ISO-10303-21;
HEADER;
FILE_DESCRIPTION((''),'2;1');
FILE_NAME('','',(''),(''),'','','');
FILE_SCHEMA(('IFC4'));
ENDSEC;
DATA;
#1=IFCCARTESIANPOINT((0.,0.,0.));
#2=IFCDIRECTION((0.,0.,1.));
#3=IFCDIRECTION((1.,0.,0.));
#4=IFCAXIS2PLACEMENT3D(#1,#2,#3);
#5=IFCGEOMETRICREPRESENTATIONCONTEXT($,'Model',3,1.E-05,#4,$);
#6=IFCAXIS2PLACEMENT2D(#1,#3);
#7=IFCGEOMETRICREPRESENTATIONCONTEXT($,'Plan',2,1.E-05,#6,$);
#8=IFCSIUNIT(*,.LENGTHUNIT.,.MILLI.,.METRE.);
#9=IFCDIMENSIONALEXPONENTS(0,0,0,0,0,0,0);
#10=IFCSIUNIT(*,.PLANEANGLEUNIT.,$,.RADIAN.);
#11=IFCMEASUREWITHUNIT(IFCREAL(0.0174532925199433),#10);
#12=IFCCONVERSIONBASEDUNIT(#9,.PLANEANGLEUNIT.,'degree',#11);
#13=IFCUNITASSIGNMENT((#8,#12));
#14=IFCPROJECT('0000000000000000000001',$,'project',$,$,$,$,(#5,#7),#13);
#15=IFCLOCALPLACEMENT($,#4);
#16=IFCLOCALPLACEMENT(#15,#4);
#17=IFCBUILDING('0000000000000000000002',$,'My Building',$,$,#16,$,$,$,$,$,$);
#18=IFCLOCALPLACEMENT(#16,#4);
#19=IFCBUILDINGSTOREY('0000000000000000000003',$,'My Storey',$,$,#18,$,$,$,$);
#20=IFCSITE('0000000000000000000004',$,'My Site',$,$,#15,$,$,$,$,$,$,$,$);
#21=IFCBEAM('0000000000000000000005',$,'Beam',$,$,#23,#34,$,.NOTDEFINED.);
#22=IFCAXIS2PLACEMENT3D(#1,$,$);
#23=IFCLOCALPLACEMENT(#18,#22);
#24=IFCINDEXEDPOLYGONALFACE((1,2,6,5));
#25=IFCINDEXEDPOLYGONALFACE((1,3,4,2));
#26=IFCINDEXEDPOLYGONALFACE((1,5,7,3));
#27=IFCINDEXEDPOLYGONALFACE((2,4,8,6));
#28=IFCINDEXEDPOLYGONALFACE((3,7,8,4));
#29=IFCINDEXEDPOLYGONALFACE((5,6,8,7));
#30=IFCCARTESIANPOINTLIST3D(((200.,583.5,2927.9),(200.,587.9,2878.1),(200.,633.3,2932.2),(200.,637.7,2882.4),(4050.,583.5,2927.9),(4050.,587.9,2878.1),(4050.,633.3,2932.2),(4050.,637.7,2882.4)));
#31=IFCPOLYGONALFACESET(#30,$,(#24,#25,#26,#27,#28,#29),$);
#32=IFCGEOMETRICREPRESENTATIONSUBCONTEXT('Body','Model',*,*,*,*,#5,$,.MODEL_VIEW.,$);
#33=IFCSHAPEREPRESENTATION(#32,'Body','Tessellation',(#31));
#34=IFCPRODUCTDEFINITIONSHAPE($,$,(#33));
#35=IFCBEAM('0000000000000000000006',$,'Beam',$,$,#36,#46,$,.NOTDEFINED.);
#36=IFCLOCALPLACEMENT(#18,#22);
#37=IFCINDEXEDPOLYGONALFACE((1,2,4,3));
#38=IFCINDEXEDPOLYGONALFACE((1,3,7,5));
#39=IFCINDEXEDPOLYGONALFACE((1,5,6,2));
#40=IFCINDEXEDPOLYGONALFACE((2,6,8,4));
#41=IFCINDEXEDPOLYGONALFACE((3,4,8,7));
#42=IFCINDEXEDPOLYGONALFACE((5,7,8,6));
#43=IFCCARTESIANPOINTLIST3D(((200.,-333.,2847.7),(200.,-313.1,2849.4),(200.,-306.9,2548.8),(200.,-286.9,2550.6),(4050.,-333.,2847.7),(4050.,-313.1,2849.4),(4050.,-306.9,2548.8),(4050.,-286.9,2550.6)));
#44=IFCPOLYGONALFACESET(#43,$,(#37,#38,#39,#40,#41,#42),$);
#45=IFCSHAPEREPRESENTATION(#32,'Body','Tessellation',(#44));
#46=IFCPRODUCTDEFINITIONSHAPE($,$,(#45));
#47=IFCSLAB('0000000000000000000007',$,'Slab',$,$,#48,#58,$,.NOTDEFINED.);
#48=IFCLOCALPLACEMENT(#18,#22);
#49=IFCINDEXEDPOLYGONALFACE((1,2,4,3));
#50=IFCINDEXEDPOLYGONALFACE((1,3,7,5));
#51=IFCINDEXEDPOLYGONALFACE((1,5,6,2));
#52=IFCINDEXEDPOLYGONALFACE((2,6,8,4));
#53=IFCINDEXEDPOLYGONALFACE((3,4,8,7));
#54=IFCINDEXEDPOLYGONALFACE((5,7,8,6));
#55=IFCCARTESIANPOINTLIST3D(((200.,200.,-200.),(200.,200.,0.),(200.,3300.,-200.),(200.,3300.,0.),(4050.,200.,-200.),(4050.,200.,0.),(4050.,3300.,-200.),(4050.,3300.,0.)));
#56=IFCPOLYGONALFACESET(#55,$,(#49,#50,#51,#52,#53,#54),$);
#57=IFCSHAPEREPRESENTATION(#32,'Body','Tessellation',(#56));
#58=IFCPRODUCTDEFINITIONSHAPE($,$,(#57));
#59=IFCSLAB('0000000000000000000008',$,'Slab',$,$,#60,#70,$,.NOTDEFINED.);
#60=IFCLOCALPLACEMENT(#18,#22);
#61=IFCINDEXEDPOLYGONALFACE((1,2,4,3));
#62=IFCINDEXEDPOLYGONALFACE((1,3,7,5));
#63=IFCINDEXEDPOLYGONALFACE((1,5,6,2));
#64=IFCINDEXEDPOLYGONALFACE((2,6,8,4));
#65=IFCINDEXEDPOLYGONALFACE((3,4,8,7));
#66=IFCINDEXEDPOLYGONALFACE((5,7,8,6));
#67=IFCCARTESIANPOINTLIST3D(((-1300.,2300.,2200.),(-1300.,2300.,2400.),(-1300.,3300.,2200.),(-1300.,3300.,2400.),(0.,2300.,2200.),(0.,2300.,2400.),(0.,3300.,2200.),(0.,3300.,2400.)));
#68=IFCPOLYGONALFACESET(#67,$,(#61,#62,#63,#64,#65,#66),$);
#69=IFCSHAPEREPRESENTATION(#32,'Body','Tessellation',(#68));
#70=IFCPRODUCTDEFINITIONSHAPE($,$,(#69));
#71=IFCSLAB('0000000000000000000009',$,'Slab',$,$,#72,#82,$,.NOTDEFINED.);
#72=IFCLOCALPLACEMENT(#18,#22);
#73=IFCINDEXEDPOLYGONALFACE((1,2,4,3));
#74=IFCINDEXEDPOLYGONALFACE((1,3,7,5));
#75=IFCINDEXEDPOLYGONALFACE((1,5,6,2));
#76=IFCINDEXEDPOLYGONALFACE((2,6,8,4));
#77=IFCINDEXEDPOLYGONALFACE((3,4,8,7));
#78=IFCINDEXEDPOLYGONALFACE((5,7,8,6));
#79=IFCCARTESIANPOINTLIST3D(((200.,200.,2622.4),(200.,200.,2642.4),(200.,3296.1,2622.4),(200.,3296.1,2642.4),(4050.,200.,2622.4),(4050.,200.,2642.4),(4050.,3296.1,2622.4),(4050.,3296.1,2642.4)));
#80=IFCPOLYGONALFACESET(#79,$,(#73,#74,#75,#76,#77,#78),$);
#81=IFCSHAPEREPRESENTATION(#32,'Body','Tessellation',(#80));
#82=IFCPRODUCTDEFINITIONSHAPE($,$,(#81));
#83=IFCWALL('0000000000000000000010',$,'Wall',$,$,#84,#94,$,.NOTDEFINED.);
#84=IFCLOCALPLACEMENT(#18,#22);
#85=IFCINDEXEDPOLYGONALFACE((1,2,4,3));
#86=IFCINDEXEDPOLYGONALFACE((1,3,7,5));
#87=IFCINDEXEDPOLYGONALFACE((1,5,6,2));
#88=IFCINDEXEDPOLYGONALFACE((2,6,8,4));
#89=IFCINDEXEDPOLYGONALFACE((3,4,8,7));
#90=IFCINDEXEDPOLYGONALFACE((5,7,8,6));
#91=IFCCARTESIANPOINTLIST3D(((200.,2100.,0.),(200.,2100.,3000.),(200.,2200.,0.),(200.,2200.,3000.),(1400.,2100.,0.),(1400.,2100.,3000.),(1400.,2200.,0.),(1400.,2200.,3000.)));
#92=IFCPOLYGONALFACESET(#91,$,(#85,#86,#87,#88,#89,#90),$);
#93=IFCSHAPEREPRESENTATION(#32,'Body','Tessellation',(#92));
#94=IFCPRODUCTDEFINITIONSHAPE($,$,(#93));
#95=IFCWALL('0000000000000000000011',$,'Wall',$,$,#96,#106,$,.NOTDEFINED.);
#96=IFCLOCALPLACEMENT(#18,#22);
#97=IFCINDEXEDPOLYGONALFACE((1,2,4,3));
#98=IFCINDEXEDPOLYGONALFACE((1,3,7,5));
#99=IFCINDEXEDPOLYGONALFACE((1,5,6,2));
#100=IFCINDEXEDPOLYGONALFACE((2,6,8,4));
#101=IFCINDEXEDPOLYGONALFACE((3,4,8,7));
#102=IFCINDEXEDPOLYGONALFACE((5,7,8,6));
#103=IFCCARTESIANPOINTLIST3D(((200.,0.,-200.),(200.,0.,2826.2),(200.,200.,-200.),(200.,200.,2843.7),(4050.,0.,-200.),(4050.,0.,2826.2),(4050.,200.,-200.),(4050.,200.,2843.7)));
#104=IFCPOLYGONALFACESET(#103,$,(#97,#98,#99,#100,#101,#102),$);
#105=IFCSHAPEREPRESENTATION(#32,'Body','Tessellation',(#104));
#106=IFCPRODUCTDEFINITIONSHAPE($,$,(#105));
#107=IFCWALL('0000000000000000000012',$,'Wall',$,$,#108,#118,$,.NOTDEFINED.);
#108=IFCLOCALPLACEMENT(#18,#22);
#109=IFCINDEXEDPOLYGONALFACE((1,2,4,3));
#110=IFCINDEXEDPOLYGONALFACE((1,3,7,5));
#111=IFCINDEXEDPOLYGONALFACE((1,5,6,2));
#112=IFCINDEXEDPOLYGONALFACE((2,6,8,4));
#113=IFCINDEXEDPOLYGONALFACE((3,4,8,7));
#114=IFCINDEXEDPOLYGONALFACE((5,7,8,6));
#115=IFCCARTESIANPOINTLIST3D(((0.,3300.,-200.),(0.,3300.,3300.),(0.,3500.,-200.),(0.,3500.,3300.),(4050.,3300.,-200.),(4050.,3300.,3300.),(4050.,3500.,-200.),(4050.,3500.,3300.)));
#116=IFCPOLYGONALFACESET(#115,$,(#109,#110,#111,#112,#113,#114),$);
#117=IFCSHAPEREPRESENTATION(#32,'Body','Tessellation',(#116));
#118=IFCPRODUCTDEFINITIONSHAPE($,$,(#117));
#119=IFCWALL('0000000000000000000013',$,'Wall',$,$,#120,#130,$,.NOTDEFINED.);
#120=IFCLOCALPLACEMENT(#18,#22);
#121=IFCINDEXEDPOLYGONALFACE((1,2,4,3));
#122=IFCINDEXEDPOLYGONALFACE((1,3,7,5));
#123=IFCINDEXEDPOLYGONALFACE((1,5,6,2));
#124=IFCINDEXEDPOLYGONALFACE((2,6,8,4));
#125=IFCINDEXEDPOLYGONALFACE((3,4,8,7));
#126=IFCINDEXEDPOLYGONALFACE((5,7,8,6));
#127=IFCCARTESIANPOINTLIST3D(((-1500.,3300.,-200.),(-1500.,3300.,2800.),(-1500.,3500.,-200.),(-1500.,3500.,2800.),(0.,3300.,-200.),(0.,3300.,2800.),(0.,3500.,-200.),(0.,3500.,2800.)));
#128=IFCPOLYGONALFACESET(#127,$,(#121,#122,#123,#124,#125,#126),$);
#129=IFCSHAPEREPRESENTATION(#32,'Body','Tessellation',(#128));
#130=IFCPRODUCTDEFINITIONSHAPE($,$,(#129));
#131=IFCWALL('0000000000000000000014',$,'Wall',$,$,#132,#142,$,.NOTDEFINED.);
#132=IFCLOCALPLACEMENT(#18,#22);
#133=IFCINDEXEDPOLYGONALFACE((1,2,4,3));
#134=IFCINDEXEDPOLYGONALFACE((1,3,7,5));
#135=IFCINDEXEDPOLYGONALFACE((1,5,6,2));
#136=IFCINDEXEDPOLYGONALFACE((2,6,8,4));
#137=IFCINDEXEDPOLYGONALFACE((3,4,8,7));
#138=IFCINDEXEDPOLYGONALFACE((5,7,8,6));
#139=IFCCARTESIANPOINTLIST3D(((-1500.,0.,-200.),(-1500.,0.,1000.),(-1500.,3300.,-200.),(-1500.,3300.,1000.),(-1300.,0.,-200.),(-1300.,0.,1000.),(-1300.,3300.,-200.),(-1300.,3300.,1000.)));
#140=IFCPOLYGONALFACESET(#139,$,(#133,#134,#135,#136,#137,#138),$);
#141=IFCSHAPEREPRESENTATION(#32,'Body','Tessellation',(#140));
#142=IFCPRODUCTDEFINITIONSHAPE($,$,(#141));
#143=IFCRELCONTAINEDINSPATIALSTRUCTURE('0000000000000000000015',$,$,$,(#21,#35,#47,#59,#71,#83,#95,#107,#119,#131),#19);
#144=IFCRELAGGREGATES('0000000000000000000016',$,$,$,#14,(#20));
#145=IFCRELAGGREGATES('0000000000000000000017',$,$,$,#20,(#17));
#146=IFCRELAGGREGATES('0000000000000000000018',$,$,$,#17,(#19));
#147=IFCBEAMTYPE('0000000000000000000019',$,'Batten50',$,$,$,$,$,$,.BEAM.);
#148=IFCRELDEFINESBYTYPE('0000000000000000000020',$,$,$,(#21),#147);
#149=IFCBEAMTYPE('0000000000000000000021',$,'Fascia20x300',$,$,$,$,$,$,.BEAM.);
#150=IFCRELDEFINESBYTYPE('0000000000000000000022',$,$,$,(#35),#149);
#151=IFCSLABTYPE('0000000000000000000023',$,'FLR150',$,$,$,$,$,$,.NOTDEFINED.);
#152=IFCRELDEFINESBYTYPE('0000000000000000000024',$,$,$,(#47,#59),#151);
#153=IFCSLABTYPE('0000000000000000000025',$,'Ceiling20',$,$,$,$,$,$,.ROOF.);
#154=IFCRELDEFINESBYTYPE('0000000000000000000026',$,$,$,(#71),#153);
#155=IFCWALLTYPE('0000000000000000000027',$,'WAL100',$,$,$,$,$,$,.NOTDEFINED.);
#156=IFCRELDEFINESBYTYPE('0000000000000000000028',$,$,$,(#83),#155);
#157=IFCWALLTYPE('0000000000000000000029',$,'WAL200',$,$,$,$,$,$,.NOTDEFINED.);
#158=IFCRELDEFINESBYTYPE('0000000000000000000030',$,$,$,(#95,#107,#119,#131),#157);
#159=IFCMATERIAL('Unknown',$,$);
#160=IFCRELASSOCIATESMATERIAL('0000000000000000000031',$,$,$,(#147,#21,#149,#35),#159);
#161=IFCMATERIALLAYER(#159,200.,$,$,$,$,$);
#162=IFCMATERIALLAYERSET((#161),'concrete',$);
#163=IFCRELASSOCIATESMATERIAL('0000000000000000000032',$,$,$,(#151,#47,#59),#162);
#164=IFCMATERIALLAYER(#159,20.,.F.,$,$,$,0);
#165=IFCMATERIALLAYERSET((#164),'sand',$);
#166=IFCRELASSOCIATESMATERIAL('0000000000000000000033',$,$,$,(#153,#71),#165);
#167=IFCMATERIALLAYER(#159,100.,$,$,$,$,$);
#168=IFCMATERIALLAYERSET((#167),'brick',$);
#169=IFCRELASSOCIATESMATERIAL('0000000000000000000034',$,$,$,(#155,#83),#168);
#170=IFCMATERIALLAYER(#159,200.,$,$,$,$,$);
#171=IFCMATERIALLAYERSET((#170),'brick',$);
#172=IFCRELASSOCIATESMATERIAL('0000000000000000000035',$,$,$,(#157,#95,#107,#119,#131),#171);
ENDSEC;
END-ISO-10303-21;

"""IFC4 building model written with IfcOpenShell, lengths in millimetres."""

from ifc_helpers import new_model, entity, si_unit, converted_unit, frame, frame_2d, origin_with_axes, place, context, subcontext, project, spatial, line, indexed_curve, rectangle, outline, extrude, clip, halfspace, material, layer, layer_set, layer_usage, material_profile, profile_set, profile_usage, type_object, element, save


model = new_model("IFC4")

# Units and contexts
model_context = context("Model", 3, precision=1e-05, world=origin_with_axes())
plan_context = context("Plan", 2, precision=1e-05, world=frame_2d((0.0, 0.0, 0.0), x_axis=(1.0, 0.0, 0.0)))
body_context = subcontext(model_context, "Body", "Model", "MODEL_VIEW")
ifc_project = project(units=[si_unit("LENGTHUNIT", "METRE", prefix="MILLI"), converted_unit("PLANEANGLEUNIT", "degree", entity("IfcReal", 0.0174532925199433), si_unit("PLANEANGLEUNIT", "RADIAN"), dimensions=[0, 0, 0, 0, 0, 0, 0])], contexts=[model_context, plan_context])

# Site, building, storey
site_placement = place(None, origin_with_axes())
site = spatial("IfcSite", under=ifc_project, at=site_placement, Name="My Site")
building_placement = place(site_placement, origin_with_axes())
building = spatial("IfcBuilding", under=site, at=building_placement, Name="My Building")
storey_placement = place(building_placement, origin_with_axes())
storey = spatial("IfcBuildingStorey", under=building, at=storey_placement, Name="My Storey")

# Shared definitions
ifc_material = material(Name="Unknown")

# Beams
ifc_material_profile_1 = material_profile(ifc_material, rectangle(XDim=50.0, YDim=50.0))
ifc_profile_set_1 = profile_set([ifc_material_profile_1], Name="blank")
beam_type_1 = type_object("IfcBeamType", Name="Batten50", PredefinedType="BEAM", material=ifc_profile_set_1)
ifc_profile_usage_1 = profile_usage(ifc_profile_set_1, cardinal=5)
beam_1_placement = place(storey_placement, frame((200.0, 610.6, 2905.1), z_axis=(1.0, 0.0, 0.0), x_axis=(0.0, 0.996195, 0.087156)))
element("IfcBeam", 1, at=beam_1_placement, inside=storey, type_object=beam_type_1, material=ifc_profile_usage_1, Name="Beam", PredefinedType="NOTDEFINED", context=body_context, shape_type="SweptSolid", body=[
    extrude(rectangle(XDim=50.0, YDim=50.0), origin_with_axes(), (0.0, 0.0, 1.0), 3850.0),
])
ifc_material_profile_2 = material_profile(ifc_material, rectangle(XDim=20.0, YDim=300.0))
ifc_profile_set_2 = profile_set([ifc_material_profile_2], Name="sand")
ifc_profile_usage_2 = profile_usage(ifc_profile_set_2, cardinal=5)
beam_type_2 = type_object("IfcBeamType", Name="Fascia20x300", PredefinedType="BEAM", material=ifc_profile_set_2)
beam_2_placement = place(storey_placement, frame((200.0, -310.0, 2699.1), z_axis=(1.0, 0.0, 0.0), x_axis=(0.0, 0.996195, 0.087156)))
element("IfcBeam", 2, at=beam_2_placement, inside=storey, type_object=beam_type_2, material=ifc_profile_usage_2, Name="Beam", PredefinedType="NOTDEFINED", context=body_context, shape_type="SweptSolid", body=[
    extrude(rectangle(XDim=20.0, YDim=300.0), origin_with_axes(), (0.0, 0.0, 1.0), 3850.0),
])

# Slabs
ifc_layer_1 = layer(ifc_material, 200.0)
ifc_layer_set_1 = layer_set([ifc_layer_1], Name="concrete")
ifc_layer_usage_1 = layer_usage(ifc_layer_set_1, "AXIS3", "POSITIVE", 0.0)
slab_type_1 = type_object("IfcSlabType", Name="FLR150", PredefinedType="NOTDEFINED", material=ifc_layer_set_1)
slab_1_placement = place(storey_placement, frame((200.0, 200.0, -200.0), z_axis=(0.0, 0.0, 1.0), x_axis=(1.0, 0.0, 0.0)))
element("IfcSlab", 3, at=slab_1_placement, inside=storey, type_object=slab_type_1, material=ifc_layer_usage_1, Name="Slab", PredefinedType="NOTDEFINED", context=body_context, shape_type="SweptSolid", body=[
    extrude(outline(indexed_curve([(0.0, 0.0), (3850.0, 0.0), (3850.0, 3100.0), (0.0, 3100.0)], segments=[line(3, 2), line(2, 1), line(1, 4), line(4, 3)], self_intersect=False)), None, (0.0, 0.0, 1.0), 200.0),
])
ifc_layer_usage_2 = layer_usage(ifc_layer_set_1, "AXIS3", "POSITIVE", 0.0)
slab_2_placement = place(storey_placement, frame((-1300.0, 2300.0, 2200.0), z_axis=(0.0, 0.0, 1.0), x_axis=(1.0, 0.0, 0.0)))
element("IfcSlab", 4, at=slab_2_placement, inside=storey, type_object=slab_type_1, material=ifc_layer_usage_2, Name="Slab", PredefinedType="NOTDEFINED", context=body_context, shape_type="SweptSolid", body=[
    extrude(outline(indexed_curve([(0.0, 0.0), (1300.0, 0.0), (1300.0, 1000.0), (0.0, 1000.0)], segments=[line(3, 2), line(2, 1), line(1, 4), line(4, 3)], self_intersect=False)), None, (0.0, 0.0, 1.0), 200.0),
])
ifc_layer_2 = layer(ifc_material, 20.0, ventilated=False, Priority=0)
ifc_layer_set_2 = layer_set([ifc_layer_2], Name="sand")
ifc_layer_usage_3 = layer_usage(ifc_layer_set_2, "AXIS3", "POSITIVE", 0.0)
slab_type_2 = type_object("IfcSlabType", Name="Ceiling20", PredefinedType="ROOF", material=ifc_layer_set_2)
slab_3_placement = place(storey_placement, frame((200.0, 200.0, 2622.4), z_axis=(0.0, 0.0, 1.0), x_axis=(1.0, 0.0, 0.0)))
element("IfcSlab", 5, at=slab_3_placement, inside=storey, type_object=slab_type_2, material=ifc_layer_usage_3, Name="Slab", PredefinedType="NOTDEFINED", context=body_context, shape_type="SweptSolid", body=[
    extrude(outline(indexed_curve([(0.0, 0.0), (3850.0, 0.0), (3850.0, 3096.1), (0.0, 3096.1)], segments=[line(3, 2), line(2, 1), line(1, 4), line(4, 3)], self_intersect=False)), None, (0.0, 0.0, 1.0), 20.0),
])

# Walls
ifc_layer_3 = layer(ifc_material, 100.0)
ifc_layer_set_3 = layer_set([ifc_layer_3], Name="brick")
ifc_layer_usage_4 = layer_usage(ifc_layer_set_3, "AXIS2", "POSITIVE", 0.0)
wall_type_1 = type_object("IfcWallType", Name="WAL100", PredefinedType="NOTDEFINED", material=ifc_layer_set_3)
wall_1_placement = place(storey_placement, frame((200.0, 2100.0, 0.0), z_axis=(0.0, 0.0, 1.0), x_axis=(1.0, 0.0, 0.0)))
element("IfcWall", 6, at=wall_1_placement, inside=storey, type_object=wall_type_1, material=ifc_layer_usage_4, Name="Wall", PredefinedType="NOTDEFINED", context=body_context, shape_type="SweptSolid", body=[
    extrude(outline(indexed_curve([(0.0, 0.0), (0.0, 100.0), (1200.0, 100.0), (1200.0, 0.0), (0.0, 0.0)], self_intersect=False)), origin_with_axes(), (0.0, 0.0, 1.0), 3000.0),
])
ifc_layer_4 = layer(ifc_material, 200.0)
ifc_layer_set_4 = layer_set([ifc_layer_4], Name="brick")
ifc_layer_usage_5 = layer_usage(ifc_layer_set_4, "AXIS2", "POSITIVE", 0.0)
wall_type_2 = type_object("IfcWallType", Name="WAL200", PredefinedType="NOTDEFINED", material=ifc_layer_set_4)
wall_2_placement = place(storey_placement, frame((200.0, 0.0, -200.0), z_axis=(0.0, 0.0, 1.0), x_axis=(1.0, 0.0, 0.0)))
element("IfcWall", 7, at=wall_2_placement, inside=storey, type_object=wall_type_2, material=ifc_layer_usage_5, Name="Wall", PredefinedType="NOTDEFINED", context=body_context, shape_type="Clipping", body=[
    clip(extrude(outline(indexed_curve([(0.0, 0.0), (0.0, 200.0), (3850.0, 200.0), (3850.0, 0.0), (0.0, 0.0)], self_intersect=False)), origin_with_axes(), (0.0, 0.0, 1.0), 3043.7), halfspace(frame((0.0, 200.0, 3043.7), z_axis=(0.0, -0.087156, 0.996195), x_axis=(1.0, 0.0, 0.0)), False)),
])
ifc_layer_usage_6 = layer_usage(ifc_layer_set_4, "AXIS2", "POSITIVE", 0.0)
wall_3_placement = place(storey_placement, frame((4050.0, 3500.0, -200.0), z_axis=(0.0, 0.0, 1.0), x_axis=(-1.0, 0.0, 0.0)))
element("IfcWall", 8, at=wall_3_placement, inside=storey, type_object=wall_type_2, material=ifc_layer_usage_6, Name="Wall", PredefinedType="NOTDEFINED", context=body_context, shape_type="SweptSolid", body=[
    extrude(outline(indexed_curve([(0.0, 0.0), (0.0, 200.0), (4050.0, 200.0), (4050.0, 0.0), (0.0, 0.0)], self_intersect=False)), origin_with_axes(), (0.0, 0.0, 1.0), 3500.0),
])
ifc_layer_usage_7 = layer_usage(ifc_layer_set_4, "AXIS2", "POSITIVE", 0.0)
wall_4_placement = place(storey_placement, frame((0.0, 3500.0, -200.0), z_axis=(0.0, 0.0, 1.0), x_axis=(-1.0, 0.0, 0.0)))
element("IfcWall", 9, at=wall_4_placement, inside=storey, type_object=wall_type_2, material=ifc_layer_usage_7, Name="Wall", PredefinedType="NOTDEFINED", context=body_context, shape_type="SweptSolid", body=[
    extrude(outline(indexed_curve([(0.0, 0.0), (0.0, 200.0), (1500.0, 200.0), (1500.0, 0.0), (0.0, 0.0)], self_intersect=False)), origin_with_axes(), (0.0, 0.0, 1.0), 3000.0),
])
ifc_layer_usage_8 = layer_usage(ifc_layer_set_4, "AXIS2", "POSITIVE", 0.0)
wall_5_placement = place(storey_placement, frame((-1500.0, 3300.0, -200.0), z_axis=(0.0, 0.0, 1.0), x_axis=(0.0, -1.0, 0.0)))
element("IfcWall", 10, at=wall_5_placement, inside=storey, type_object=wall_type_2, material=ifc_layer_usage_8, Name="Wall", PredefinedType="NOTDEFINED", context=body_context, shape_type="SweptSolid", body=[
    extrude(outline(indexed_curve([(0.0, 0.0), (0.0, 200.0), (3300.0, 200.0), (3300.0, 0.0), (0.0, 0.0)], self_intersect=False)), origin_with_axes(), (0.0, 0.0, 1.0), 1200.0),
])

save(model, "model.ifc")
